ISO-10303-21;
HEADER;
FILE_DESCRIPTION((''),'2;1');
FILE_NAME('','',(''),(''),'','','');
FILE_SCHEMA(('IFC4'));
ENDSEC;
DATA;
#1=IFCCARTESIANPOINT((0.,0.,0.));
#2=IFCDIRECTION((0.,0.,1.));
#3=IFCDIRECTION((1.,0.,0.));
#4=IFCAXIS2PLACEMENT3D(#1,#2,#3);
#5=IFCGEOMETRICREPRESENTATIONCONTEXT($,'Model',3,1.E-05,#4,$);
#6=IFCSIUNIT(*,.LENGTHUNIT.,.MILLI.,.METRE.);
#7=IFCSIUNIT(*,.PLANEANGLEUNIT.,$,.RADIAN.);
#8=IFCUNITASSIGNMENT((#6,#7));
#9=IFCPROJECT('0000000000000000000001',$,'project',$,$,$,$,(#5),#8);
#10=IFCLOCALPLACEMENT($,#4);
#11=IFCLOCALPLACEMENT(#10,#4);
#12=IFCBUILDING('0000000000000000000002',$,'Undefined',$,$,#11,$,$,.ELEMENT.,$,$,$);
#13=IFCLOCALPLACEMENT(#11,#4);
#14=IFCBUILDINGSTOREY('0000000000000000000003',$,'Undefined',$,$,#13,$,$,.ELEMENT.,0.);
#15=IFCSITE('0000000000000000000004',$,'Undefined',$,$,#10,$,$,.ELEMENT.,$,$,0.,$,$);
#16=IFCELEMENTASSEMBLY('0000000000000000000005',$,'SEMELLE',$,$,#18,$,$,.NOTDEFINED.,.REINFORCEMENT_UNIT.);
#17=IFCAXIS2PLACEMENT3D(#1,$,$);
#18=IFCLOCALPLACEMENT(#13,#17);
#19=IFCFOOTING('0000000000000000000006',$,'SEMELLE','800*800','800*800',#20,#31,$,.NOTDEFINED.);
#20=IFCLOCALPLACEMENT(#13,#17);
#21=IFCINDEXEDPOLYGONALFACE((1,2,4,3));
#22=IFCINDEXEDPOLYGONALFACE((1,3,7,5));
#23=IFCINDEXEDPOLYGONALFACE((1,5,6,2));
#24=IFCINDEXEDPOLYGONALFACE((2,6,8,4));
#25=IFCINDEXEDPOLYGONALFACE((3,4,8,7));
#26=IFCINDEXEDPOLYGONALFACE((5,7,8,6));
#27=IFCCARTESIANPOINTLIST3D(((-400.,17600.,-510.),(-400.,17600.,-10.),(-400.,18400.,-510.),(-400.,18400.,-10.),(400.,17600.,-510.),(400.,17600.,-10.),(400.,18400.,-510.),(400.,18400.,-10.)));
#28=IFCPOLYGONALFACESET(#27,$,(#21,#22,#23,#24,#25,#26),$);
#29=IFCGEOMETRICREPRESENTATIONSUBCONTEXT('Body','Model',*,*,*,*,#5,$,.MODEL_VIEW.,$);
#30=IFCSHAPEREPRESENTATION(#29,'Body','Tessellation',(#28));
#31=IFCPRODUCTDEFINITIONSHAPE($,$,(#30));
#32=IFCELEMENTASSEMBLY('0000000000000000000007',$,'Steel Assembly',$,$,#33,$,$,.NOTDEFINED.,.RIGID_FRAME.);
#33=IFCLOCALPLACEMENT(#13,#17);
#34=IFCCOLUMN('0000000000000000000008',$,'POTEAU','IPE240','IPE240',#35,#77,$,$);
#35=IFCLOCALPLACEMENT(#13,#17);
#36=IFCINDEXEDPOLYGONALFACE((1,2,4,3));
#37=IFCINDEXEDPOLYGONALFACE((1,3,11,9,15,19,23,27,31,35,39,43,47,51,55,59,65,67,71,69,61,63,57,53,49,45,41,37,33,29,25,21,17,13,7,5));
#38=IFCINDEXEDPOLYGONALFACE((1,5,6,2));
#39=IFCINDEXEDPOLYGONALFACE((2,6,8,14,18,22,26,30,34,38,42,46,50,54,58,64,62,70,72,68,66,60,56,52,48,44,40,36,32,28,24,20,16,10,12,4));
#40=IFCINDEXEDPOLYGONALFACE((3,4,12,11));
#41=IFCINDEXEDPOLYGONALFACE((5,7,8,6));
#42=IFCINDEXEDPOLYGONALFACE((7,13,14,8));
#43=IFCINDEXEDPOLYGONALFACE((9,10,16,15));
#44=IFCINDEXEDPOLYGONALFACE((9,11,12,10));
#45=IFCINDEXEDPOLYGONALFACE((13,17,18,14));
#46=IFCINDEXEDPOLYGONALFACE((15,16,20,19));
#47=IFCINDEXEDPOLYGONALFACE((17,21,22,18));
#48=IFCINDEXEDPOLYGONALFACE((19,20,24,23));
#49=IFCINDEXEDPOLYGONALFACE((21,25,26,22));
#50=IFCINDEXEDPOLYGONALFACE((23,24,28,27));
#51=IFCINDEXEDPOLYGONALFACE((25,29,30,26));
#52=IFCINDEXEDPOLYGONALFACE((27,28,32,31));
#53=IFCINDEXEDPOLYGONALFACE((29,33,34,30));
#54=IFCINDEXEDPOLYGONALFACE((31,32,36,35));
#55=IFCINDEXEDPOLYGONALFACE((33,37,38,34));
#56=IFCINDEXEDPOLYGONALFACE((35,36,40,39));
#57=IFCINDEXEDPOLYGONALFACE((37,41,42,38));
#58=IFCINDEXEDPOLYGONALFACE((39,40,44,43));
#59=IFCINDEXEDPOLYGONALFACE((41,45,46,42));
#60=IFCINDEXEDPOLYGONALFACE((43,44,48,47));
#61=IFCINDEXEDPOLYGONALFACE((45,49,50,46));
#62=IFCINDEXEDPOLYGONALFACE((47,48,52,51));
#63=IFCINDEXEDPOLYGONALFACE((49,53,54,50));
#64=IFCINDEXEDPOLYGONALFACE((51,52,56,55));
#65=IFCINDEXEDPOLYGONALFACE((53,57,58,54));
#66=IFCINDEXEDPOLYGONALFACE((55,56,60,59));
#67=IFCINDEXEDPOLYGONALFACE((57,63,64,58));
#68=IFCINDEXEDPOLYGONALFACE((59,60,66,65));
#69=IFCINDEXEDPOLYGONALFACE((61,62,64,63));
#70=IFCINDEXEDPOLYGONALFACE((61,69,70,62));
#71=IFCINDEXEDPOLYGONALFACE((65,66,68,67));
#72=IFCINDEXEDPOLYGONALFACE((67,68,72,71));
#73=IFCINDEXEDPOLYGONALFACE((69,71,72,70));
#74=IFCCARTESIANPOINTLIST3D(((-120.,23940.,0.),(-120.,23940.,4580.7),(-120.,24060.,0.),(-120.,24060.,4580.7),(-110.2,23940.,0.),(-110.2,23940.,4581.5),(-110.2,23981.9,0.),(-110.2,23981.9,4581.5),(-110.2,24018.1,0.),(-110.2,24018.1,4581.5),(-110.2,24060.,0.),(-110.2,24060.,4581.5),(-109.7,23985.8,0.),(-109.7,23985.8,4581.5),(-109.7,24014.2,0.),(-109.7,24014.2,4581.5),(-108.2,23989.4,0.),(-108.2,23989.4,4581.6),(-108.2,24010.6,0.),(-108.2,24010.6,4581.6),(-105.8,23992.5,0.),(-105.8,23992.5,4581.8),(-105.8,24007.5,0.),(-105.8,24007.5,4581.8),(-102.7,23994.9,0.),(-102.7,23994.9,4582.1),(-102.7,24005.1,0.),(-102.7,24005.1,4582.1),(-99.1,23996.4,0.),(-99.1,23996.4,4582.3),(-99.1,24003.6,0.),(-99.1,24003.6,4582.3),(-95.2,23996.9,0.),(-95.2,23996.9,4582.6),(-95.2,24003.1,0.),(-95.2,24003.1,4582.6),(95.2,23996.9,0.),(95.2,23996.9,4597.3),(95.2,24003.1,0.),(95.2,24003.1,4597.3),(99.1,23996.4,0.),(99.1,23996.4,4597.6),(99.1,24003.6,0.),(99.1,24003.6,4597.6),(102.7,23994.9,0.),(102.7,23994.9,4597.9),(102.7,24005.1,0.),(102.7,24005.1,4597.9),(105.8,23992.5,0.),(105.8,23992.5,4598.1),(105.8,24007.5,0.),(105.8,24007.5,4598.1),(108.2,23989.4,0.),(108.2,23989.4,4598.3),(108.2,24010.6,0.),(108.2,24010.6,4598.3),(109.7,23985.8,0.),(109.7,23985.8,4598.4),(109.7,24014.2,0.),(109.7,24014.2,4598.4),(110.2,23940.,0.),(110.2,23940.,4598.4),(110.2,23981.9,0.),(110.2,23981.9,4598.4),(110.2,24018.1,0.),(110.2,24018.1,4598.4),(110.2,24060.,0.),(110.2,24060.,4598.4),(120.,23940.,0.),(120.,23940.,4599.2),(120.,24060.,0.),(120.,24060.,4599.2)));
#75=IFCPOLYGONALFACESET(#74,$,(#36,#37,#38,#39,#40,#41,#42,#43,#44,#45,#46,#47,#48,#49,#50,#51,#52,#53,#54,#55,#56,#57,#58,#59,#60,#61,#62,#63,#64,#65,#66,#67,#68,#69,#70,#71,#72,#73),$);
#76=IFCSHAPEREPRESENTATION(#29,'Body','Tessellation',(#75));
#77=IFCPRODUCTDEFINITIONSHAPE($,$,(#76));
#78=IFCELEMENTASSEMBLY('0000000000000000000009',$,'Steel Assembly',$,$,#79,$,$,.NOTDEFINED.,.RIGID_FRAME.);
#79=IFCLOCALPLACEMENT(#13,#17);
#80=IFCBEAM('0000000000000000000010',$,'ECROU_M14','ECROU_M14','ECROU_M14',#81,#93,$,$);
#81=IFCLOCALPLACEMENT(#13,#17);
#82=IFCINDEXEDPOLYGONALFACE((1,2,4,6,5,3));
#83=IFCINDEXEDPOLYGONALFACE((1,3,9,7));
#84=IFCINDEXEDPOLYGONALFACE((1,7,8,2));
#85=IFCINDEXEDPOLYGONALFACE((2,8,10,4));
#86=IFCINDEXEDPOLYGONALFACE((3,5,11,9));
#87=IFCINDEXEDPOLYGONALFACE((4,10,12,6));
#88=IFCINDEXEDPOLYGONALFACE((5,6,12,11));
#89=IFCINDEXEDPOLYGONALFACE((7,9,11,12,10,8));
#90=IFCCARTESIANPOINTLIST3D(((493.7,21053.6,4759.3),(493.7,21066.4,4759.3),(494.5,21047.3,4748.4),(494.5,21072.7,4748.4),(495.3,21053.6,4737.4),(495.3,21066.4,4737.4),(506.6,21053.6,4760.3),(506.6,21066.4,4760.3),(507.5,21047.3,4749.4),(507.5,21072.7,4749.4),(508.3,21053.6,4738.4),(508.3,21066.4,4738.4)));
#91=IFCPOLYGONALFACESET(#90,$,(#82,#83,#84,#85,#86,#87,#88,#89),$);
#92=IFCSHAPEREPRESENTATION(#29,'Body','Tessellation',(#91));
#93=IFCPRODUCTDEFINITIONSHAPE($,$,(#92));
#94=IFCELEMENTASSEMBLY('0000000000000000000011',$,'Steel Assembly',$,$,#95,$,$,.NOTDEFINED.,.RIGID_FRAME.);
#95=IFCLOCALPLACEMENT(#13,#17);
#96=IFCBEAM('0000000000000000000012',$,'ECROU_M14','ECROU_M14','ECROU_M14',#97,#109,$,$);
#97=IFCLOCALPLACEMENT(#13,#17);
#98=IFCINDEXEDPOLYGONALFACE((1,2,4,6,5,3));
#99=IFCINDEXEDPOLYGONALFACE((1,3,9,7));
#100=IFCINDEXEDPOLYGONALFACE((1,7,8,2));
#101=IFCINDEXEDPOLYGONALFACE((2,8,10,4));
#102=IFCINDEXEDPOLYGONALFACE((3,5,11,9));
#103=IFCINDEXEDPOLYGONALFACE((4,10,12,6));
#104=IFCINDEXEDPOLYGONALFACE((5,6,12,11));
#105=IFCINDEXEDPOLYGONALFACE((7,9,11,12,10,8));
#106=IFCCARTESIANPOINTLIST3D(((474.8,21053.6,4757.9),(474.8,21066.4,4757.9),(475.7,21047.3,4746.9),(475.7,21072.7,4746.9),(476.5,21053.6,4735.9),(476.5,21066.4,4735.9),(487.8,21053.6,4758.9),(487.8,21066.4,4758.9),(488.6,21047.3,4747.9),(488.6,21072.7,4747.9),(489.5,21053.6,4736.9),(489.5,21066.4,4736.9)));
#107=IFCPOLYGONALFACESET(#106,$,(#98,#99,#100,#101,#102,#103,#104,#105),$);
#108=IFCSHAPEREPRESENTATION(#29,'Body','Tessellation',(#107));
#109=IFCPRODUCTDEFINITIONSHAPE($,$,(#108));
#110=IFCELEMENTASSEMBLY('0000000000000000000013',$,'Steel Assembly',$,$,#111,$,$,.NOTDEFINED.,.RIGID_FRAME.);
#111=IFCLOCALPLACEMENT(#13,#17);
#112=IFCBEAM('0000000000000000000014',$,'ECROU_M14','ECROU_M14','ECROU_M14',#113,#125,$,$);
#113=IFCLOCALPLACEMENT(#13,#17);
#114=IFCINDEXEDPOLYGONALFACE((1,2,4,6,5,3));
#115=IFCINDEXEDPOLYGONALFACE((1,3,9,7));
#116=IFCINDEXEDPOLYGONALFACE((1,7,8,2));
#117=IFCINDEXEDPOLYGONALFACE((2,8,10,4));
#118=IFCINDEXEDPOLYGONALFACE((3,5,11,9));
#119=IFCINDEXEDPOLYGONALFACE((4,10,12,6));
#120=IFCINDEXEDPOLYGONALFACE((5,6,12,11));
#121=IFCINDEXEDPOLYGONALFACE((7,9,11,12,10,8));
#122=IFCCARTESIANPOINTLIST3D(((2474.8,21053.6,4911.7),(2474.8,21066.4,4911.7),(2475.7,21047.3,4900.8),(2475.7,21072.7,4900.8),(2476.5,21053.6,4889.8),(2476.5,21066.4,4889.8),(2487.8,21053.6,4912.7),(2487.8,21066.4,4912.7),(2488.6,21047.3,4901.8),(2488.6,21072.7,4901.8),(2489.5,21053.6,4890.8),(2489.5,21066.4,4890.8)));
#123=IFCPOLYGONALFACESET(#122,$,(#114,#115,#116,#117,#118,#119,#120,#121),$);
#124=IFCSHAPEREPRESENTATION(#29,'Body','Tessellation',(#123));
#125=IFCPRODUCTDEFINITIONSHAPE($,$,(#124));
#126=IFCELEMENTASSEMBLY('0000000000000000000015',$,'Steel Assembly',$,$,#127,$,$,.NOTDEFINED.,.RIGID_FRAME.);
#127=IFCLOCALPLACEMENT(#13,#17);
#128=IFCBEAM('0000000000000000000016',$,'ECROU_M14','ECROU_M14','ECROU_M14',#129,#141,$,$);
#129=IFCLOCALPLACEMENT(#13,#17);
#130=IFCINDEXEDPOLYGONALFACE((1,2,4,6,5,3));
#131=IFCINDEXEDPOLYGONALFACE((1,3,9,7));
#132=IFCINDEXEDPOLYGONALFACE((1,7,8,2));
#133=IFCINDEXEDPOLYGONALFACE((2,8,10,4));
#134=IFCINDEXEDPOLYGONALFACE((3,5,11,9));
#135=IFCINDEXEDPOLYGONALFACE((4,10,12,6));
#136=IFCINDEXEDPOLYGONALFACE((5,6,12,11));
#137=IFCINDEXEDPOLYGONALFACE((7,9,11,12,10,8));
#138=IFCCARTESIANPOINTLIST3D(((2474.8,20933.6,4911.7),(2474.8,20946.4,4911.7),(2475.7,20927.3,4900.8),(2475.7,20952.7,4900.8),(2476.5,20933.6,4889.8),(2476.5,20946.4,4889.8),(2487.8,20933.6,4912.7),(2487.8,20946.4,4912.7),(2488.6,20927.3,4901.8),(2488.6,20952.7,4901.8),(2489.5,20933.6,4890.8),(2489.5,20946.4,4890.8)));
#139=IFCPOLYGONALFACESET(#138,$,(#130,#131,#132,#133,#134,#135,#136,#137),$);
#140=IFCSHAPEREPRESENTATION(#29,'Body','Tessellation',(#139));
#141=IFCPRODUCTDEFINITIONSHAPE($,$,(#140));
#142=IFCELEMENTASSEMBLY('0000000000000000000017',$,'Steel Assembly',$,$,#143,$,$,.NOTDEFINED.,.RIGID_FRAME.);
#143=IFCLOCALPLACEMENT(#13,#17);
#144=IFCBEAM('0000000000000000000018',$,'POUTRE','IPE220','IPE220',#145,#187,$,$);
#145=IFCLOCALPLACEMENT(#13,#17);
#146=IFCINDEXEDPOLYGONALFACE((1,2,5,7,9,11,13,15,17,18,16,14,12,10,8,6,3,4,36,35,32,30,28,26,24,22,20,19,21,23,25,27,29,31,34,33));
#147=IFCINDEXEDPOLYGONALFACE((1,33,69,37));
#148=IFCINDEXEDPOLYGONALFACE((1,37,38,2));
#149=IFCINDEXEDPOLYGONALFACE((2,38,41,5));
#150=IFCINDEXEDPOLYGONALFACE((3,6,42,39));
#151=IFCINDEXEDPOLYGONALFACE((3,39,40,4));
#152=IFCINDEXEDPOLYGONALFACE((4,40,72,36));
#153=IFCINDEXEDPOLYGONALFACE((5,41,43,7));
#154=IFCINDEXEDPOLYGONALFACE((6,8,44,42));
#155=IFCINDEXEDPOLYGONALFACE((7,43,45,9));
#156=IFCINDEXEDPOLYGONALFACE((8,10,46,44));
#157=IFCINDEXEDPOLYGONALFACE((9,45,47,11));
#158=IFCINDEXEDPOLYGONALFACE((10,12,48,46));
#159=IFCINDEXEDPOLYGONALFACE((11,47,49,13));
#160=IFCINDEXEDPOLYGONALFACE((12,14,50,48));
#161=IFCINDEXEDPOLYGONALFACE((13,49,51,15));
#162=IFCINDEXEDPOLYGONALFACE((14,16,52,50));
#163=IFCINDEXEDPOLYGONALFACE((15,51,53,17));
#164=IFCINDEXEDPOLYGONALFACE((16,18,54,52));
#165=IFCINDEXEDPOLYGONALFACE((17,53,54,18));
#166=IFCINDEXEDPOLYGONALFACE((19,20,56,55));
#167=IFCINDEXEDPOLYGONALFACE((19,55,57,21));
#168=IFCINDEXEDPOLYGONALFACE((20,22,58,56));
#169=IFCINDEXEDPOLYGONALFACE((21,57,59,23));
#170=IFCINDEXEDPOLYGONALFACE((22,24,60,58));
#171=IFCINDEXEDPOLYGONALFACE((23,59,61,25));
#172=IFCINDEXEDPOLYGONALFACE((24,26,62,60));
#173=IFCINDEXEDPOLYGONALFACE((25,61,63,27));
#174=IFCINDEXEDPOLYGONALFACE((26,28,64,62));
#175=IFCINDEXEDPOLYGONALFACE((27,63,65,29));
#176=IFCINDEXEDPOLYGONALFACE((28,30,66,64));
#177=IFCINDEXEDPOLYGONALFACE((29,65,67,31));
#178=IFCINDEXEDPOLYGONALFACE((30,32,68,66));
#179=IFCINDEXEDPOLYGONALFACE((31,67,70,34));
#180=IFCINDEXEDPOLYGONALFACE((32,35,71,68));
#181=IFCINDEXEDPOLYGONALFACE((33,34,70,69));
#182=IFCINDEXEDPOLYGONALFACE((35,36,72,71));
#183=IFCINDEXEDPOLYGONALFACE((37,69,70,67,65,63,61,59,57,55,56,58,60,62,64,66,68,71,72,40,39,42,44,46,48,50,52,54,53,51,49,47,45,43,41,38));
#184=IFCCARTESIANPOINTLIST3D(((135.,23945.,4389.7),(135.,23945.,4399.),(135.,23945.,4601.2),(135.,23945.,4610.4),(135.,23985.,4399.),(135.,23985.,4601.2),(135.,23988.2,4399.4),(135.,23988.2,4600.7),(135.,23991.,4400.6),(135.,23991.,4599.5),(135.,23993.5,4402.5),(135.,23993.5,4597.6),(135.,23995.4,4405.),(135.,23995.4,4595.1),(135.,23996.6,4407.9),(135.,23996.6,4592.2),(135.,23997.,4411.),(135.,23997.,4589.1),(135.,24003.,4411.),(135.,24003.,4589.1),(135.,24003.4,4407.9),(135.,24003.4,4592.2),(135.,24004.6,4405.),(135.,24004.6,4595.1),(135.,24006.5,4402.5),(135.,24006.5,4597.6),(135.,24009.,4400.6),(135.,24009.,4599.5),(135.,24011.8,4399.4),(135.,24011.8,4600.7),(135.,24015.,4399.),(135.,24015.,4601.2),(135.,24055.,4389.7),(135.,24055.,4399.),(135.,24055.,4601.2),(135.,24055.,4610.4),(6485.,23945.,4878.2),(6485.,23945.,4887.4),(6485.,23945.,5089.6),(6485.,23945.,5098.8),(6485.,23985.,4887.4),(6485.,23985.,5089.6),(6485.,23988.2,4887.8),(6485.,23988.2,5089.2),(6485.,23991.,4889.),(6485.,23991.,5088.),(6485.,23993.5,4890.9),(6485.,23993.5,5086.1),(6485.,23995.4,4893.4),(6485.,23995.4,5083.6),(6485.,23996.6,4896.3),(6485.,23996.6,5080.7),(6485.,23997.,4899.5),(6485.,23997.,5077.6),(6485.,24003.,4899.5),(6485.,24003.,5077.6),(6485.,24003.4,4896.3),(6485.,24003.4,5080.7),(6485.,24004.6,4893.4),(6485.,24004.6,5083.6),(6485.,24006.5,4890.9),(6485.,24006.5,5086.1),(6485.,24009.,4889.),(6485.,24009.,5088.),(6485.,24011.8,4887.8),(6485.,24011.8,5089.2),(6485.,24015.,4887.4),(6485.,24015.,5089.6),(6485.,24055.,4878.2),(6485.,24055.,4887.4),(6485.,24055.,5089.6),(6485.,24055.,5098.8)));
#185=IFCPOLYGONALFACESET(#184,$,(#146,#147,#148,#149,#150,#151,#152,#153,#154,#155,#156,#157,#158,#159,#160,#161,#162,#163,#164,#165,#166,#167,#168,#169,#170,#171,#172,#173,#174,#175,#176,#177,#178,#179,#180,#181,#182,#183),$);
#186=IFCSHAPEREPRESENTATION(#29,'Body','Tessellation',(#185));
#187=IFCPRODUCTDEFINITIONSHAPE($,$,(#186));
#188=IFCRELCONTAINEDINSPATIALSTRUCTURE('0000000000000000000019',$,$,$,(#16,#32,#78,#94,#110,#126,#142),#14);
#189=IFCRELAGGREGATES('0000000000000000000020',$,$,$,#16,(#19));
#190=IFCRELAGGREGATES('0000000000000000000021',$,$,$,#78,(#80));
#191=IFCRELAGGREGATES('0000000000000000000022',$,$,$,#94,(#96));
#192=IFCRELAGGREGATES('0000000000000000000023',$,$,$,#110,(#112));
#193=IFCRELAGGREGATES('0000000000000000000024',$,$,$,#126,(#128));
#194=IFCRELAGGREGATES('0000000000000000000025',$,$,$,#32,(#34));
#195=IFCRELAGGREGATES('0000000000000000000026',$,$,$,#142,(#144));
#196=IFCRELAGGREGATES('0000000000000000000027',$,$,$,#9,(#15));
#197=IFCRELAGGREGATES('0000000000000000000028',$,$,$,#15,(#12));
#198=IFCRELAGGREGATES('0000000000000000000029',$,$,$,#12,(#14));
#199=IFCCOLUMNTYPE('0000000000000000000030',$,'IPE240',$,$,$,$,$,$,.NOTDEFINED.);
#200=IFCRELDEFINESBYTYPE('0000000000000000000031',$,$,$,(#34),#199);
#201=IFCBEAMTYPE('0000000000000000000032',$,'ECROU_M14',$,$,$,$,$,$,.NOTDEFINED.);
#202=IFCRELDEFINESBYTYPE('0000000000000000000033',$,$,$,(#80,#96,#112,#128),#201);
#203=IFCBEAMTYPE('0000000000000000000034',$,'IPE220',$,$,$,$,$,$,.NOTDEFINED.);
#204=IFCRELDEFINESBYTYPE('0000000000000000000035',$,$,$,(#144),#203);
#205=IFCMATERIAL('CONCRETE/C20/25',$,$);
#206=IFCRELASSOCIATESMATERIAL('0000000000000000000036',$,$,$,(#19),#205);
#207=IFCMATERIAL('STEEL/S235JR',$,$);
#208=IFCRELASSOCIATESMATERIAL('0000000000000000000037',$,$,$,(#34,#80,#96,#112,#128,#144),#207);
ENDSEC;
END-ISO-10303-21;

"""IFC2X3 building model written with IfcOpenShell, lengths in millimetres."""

from ifc_helpers import new_model, si_unit, frame, origin_with_axes, origin_2d_with_axis, place, context, subcontext, project, spatial, polyline, rectangle, i_section, outline, extrude, clip, halfspace, material, type_object, element, aggregate, save


model = new_model("IFC2X3")

# Units and contexts
model_context = context("Model", 3, precision=1e-05, world=origin_with_axes())
body_context = subcontext(model_context, "Body", "Model", "MODEL_VIEW")
ifc_project = project(units=[si_unit("LENGTHUNIT", "METRE", prefix="MILLI"), si_unit("PLANEANGLEUNIT", "RADIAN")], contexts=[model_context])

# Site, building, storey
site_placement = place(None, origin_with_axes())
site = spatial("IfcSite", under=ifc_project, at=site_placement, Name="Undefined", CompositionType="ELEMENT", RefElevation=0.0)
building_placement = place(site_placement, origin_with_axes())
building = spatial("IfcBuilding", under=site, at=building_placement, Name="Undefined", CompositionType="ELEMENT")
storey_placement = place(building_placement, origin_with_axes())
storey = spatial("IfcBuildingStorey", under=building, at=storey_placement, Name="Undefined", CompositionType="ELEMENT", Elevation=0.0)

# Element assembly, footing
assembly_1_placement = place(storey_placement, origin_with_axes())
assembly_1 = element("IfcElementAssembly", 1, at=assembly_1_placement, inside=storey, Name="SEMELLE", AssemblyPlace="NOTDEFINED", PredefinedType="REINFORCEMENT_UNIT")
ifc_material_1 = material(Name="CONCRETE/C20/25")
footing_placement = place(assembly_1_placement, frame((0.0, 18000.0, -510.0), z_axis=(0.0, -1.0, 0.0), x_axis=(0.0, 0.0, 1.0)))
footing = element("IfcFooting", 2, at=footing_placement, material=ifc_material_1, Name="SEMELLE", Description="800*800", ObjectType="800*800", PredefinedType="NOTDEFINED", context=body_context, shape_type="SweptSolid", body=[
    extrude(rectangle(XDim=800.0, YDim=800.0, at=origin_2d_with_axis()), frame((500.0, 0.0, 0.0), z_axis=(-1.0, 0.0, 0.0), x_axis=(0.0, -1.0, 0.0)), (0.0, 0.0, 1.0), 500.0),
])
aggregate(assembly_1, [footing])

# Element assembly, column
assembly_2_placement = place(storey_placement, origin_with_axes())
assembly_2 = element("IfcElementAssembly", 3, at=assembly_2_placement, inside=storey, Name="Steel Assembly", AssemblyPlace="NOTDEFINED", PredefinedType="RIGID_FRAME")
ifc_material_2 = material(Name="STEEL/S235JR")
column_type = type_object("IfcColumnType", Name="IPE240", PredefinedType="NOTDEFINED")
column_placement = place(assembly_2_placement, frame((0.0, 24000.0, 0.0), z_axis=(0.0, 0.0, 1.0), x_axis=(1.0, 0.0, 0.0)))
column = element("IfcColumn", 4, at=column_placement, type_object=column_type, material=ifc_material_2, Name="POTEAU", Description="IPE240", ObjectType="IPE240", context=body_context, shape_type="Clipping", body=[
    clip(extrude(i_section(OverallWidth=120.0, OverallDepth=240.0, WebThickness=6.2, FlangeThickness=9.8, FilletRadius=15.0, at=origin_2d_with_axis()), frame((0.0, 0.0, 4599.3), z_axis=(0.0, 0.0, -1.0), x_axis=(0.0, 1.0, 0.0)), (0.0, 0.0, 1.0), 4599.3), halfspace(frame((170.8, 0.0, 4603.1), z_axis=(-0.076696, 0.0, 0.997054), x_axis=(0.0, -1.0, 0.0)), False)),
])

# Element assemblies, beams
assembly_3_placement = place(storey_placement, origin_with_axes())
assembly_3 = element("IfcElementAssembly", 5, at=assembly_3_placement, inside=storey, Name="Steel Assembly", AssemblyPlace="NOTDEFINED", PredefinedType="RIGID_FRAME")
beam_type_1 = type_object("IfcBeamType", Name="ECROU_M14", PredefinedType="NOTDEFINED")
beam_1_placement = place(assembly_3_placement, frame((507.5, 21060.0, 4749.4), z_axis=(-0.076696, 0.0, 0.997054), x_axis=(-0.997054, 0.0, -0.076696)))
beam_1 = element("IfcBeam", 6, at=beam_1_placement, type_object=beam_type_1, material=ifc_material_2, Name="ECROU_M14", Description="ECROU_M14", ObjectType="ECROU_M14", context=body_context, shape_type="SweptSolid", body=[
    extrude(outline(polyline([(12.7, 0.0), (6.4, -11.0), (-6.4, -11.0), (-12.7, 0.0), (-6.4, 11.0), (6.4, 11.0), (12.7, 0.0)])), frame((13.0, 0.0, 0.0), z_axis=(-1.0, 0.0, 0.0), x_axis=(0.0, -1.0, 0.0)), (0.0, 0.0, 1.0), 13.0),
])
aggregate(assembly_3, [beam_1])
assembly_4_placement = place(storey_placement, origin_with_axes())
assembly_4 = element("IfcElementAssembly", 7, at=assembly_4_placement, inside=storey, Name="Steel Assembly", AssemblyPlace="NOTDEFINED", PredefinedType="RIGID_FRAME")
beam_2_placement = place(assembly_4_placement, frame((488.6, 21060.0, 4747.9), z_axis=(-0.076696, 0.0, 0.997054), x_axis=(-0.997054, 0.0, -0.076696)))
beam_2 = element("IfcBeam", 8, at=beam_2_placement, type_object=beam_type_1, material=ifc_material_2, Name="ECROU_M14", Description="ECROU_M14", ObjectType="ECROU_M14", context=body_context, shape_type="SweptSolid", body=[
    extrude(outline(polyline([(12.7, 0.0), (6.4, -11.0), (-6.4, -11.0), (-12.7, 0.0), (-6.4, 11.0), (6.4, 11.0), (12.7, 0.0)])), frame((13.0, 0.0, 0.0), z_axis=(-1.0, 0.0, 0.0), x_axis=(0.0, -1.0, 0.0)), (0.0, 0.0, 1.0), 13.0),
])
aggregate(assembly_4, [beam_2])
assembly_5_placement = place(storey_placement, origin_with_axes())
assembly_5 = element("IfcElementAssembly", 9, at=assembly_5_placement, inside=storey, Name="Steel Assembly", AssemblyPlace="NOTDEFINED", PredefinedType="RIGID_FRAME")
beam_3_placement = place(assembly_5_placement, frame((2488.6, 21060.0, 4901.8), z_axis=(-0.076696, 0.0, 0.997054), x_axis=(-0.997054, 0.0, -0.076696)))
beam_3 = element("IfcBeam", 10, at=beam_3_placement, type_object=beam_type_1, material=ifc_material_2, Name="ECROU_M14", Description="ECROU_M14", ObjectType="ECROU_M14", context=body_context, shape_type="SweptSolid", body=[
    extrude(outline(polyline([(12.7, 0.0), (6.4, -11.0), (-6.4, -11.0), (-12.7, 0.0), (-6.4, 11.0), (6.4, 11.0), (12.7, 0.0)])), frame((13.0, 0.0, 0.0), z_axis=(-1.0, 0.0, 0.0), x_axis=(0.0, -1.0, 0.0)), (0.0, 0.0, 1.0), 13.0),
])
aggregate(assembly_5, [beam_3])
assembly_6_placement = place(storey_placement, origin_with_axes())
assembly_6 = element("IfcElementAssembly", 11, at=assembly_6_placement, inside=storey, Name="Steel Assembly", AssemblyPlace="NOTDEFINED", PredefinedType="RIGID_FRAME")
beam_4_placement = place(assembly_6_placement, frame((2488.6, 20940.0, 4901.8), z_axis=(-0.076696, 0.0, 0.997054), x_axis=(-0.997054, 0.0, -0.076696)))
beam_4 = element("IfcBeam", 12, at=beam_4_placement, type_object=beam_type_1, material=ifc_material_2, Name="ECROU_M14", Description="ECROU_M14", ObjectType="ECROU_M14", context=body_context, shape_type="SweptSolid", body=[
    extrude(outline(polyline([(12.7, 0.0), (6.4, -11.0), (-6.4, -11.0), (-12.7, 0.0), (-6.4, 11.0), (6.4, 11.0), (12.7, 0.0)])), frame((13.0, 0.0, 0.0), z_axis=(-1.0, 0.0, 0.0), x_axis=(0.0, -1.0, 0.0)), (0.0, 0.0, 1.0), 13.0),
])
aggregate(assembly_6, [beam_4])
assembly_7_placement = place(storey_placement, origin_with_axes())
assembly_7 = element("IfcElementAssembly", 13, at=assembly_7_placement, inside=storey, Name="Steel Assembly", AssemblyPlace="NOTDEFINED", PredefinedType="RIGID_FRAME")
beam_type_2 = type_object("IfcBeamType", Name="IPE220", PredefinedType="NOTDEFINED")
beam_5_placement = place(assembly_7_placement, frame((8.4, 24000.0, 4490.3), z_axis=(-0.076696, 0.0, 0.997054), x_axis=(0.997054, 0.0, 0.076696)))
beam_5 = element("IfcBeam", 14, at=beam_5_placement, type_object=beam_type_2, material=ifc_material_2, Name="POUTRE", Description="IPE220", ObjectType="IPE220", context=body_context, shape_type="Clipping", body=[
    clip(clip(extrude(i_section(OverallWidth=110.0, OverallDepth=220.0, WebThickness=5.9, FlangeThickness=9.2, FilletRadius=12.0, at=origin_2d_with_axis()), frame((6512.8, 0.0, 0.0), z_axis=(-1.0, 0.0, 0.0), x_axis=(0.0, -1.0, 0.0)), (0.0, 0.0, 1.0), 6402.9), halfspace(frame((6504.2, 0.0, 111.2), z_axis=(-0.997054, 0.0, 0.076696), x_axis=(0.0, -1.0, 0.0)), True)), halfspace(frame((118.5, 0.0, -110.0), z_axis=(0.997054, 0.0, -0.076696), x_axis=(0.0, -1.0, 0.0)), True)),
])

aggregate(assembly_2, [column])
aggregate(assembly_7, [beam_5])

save(model, "model.ifc")
